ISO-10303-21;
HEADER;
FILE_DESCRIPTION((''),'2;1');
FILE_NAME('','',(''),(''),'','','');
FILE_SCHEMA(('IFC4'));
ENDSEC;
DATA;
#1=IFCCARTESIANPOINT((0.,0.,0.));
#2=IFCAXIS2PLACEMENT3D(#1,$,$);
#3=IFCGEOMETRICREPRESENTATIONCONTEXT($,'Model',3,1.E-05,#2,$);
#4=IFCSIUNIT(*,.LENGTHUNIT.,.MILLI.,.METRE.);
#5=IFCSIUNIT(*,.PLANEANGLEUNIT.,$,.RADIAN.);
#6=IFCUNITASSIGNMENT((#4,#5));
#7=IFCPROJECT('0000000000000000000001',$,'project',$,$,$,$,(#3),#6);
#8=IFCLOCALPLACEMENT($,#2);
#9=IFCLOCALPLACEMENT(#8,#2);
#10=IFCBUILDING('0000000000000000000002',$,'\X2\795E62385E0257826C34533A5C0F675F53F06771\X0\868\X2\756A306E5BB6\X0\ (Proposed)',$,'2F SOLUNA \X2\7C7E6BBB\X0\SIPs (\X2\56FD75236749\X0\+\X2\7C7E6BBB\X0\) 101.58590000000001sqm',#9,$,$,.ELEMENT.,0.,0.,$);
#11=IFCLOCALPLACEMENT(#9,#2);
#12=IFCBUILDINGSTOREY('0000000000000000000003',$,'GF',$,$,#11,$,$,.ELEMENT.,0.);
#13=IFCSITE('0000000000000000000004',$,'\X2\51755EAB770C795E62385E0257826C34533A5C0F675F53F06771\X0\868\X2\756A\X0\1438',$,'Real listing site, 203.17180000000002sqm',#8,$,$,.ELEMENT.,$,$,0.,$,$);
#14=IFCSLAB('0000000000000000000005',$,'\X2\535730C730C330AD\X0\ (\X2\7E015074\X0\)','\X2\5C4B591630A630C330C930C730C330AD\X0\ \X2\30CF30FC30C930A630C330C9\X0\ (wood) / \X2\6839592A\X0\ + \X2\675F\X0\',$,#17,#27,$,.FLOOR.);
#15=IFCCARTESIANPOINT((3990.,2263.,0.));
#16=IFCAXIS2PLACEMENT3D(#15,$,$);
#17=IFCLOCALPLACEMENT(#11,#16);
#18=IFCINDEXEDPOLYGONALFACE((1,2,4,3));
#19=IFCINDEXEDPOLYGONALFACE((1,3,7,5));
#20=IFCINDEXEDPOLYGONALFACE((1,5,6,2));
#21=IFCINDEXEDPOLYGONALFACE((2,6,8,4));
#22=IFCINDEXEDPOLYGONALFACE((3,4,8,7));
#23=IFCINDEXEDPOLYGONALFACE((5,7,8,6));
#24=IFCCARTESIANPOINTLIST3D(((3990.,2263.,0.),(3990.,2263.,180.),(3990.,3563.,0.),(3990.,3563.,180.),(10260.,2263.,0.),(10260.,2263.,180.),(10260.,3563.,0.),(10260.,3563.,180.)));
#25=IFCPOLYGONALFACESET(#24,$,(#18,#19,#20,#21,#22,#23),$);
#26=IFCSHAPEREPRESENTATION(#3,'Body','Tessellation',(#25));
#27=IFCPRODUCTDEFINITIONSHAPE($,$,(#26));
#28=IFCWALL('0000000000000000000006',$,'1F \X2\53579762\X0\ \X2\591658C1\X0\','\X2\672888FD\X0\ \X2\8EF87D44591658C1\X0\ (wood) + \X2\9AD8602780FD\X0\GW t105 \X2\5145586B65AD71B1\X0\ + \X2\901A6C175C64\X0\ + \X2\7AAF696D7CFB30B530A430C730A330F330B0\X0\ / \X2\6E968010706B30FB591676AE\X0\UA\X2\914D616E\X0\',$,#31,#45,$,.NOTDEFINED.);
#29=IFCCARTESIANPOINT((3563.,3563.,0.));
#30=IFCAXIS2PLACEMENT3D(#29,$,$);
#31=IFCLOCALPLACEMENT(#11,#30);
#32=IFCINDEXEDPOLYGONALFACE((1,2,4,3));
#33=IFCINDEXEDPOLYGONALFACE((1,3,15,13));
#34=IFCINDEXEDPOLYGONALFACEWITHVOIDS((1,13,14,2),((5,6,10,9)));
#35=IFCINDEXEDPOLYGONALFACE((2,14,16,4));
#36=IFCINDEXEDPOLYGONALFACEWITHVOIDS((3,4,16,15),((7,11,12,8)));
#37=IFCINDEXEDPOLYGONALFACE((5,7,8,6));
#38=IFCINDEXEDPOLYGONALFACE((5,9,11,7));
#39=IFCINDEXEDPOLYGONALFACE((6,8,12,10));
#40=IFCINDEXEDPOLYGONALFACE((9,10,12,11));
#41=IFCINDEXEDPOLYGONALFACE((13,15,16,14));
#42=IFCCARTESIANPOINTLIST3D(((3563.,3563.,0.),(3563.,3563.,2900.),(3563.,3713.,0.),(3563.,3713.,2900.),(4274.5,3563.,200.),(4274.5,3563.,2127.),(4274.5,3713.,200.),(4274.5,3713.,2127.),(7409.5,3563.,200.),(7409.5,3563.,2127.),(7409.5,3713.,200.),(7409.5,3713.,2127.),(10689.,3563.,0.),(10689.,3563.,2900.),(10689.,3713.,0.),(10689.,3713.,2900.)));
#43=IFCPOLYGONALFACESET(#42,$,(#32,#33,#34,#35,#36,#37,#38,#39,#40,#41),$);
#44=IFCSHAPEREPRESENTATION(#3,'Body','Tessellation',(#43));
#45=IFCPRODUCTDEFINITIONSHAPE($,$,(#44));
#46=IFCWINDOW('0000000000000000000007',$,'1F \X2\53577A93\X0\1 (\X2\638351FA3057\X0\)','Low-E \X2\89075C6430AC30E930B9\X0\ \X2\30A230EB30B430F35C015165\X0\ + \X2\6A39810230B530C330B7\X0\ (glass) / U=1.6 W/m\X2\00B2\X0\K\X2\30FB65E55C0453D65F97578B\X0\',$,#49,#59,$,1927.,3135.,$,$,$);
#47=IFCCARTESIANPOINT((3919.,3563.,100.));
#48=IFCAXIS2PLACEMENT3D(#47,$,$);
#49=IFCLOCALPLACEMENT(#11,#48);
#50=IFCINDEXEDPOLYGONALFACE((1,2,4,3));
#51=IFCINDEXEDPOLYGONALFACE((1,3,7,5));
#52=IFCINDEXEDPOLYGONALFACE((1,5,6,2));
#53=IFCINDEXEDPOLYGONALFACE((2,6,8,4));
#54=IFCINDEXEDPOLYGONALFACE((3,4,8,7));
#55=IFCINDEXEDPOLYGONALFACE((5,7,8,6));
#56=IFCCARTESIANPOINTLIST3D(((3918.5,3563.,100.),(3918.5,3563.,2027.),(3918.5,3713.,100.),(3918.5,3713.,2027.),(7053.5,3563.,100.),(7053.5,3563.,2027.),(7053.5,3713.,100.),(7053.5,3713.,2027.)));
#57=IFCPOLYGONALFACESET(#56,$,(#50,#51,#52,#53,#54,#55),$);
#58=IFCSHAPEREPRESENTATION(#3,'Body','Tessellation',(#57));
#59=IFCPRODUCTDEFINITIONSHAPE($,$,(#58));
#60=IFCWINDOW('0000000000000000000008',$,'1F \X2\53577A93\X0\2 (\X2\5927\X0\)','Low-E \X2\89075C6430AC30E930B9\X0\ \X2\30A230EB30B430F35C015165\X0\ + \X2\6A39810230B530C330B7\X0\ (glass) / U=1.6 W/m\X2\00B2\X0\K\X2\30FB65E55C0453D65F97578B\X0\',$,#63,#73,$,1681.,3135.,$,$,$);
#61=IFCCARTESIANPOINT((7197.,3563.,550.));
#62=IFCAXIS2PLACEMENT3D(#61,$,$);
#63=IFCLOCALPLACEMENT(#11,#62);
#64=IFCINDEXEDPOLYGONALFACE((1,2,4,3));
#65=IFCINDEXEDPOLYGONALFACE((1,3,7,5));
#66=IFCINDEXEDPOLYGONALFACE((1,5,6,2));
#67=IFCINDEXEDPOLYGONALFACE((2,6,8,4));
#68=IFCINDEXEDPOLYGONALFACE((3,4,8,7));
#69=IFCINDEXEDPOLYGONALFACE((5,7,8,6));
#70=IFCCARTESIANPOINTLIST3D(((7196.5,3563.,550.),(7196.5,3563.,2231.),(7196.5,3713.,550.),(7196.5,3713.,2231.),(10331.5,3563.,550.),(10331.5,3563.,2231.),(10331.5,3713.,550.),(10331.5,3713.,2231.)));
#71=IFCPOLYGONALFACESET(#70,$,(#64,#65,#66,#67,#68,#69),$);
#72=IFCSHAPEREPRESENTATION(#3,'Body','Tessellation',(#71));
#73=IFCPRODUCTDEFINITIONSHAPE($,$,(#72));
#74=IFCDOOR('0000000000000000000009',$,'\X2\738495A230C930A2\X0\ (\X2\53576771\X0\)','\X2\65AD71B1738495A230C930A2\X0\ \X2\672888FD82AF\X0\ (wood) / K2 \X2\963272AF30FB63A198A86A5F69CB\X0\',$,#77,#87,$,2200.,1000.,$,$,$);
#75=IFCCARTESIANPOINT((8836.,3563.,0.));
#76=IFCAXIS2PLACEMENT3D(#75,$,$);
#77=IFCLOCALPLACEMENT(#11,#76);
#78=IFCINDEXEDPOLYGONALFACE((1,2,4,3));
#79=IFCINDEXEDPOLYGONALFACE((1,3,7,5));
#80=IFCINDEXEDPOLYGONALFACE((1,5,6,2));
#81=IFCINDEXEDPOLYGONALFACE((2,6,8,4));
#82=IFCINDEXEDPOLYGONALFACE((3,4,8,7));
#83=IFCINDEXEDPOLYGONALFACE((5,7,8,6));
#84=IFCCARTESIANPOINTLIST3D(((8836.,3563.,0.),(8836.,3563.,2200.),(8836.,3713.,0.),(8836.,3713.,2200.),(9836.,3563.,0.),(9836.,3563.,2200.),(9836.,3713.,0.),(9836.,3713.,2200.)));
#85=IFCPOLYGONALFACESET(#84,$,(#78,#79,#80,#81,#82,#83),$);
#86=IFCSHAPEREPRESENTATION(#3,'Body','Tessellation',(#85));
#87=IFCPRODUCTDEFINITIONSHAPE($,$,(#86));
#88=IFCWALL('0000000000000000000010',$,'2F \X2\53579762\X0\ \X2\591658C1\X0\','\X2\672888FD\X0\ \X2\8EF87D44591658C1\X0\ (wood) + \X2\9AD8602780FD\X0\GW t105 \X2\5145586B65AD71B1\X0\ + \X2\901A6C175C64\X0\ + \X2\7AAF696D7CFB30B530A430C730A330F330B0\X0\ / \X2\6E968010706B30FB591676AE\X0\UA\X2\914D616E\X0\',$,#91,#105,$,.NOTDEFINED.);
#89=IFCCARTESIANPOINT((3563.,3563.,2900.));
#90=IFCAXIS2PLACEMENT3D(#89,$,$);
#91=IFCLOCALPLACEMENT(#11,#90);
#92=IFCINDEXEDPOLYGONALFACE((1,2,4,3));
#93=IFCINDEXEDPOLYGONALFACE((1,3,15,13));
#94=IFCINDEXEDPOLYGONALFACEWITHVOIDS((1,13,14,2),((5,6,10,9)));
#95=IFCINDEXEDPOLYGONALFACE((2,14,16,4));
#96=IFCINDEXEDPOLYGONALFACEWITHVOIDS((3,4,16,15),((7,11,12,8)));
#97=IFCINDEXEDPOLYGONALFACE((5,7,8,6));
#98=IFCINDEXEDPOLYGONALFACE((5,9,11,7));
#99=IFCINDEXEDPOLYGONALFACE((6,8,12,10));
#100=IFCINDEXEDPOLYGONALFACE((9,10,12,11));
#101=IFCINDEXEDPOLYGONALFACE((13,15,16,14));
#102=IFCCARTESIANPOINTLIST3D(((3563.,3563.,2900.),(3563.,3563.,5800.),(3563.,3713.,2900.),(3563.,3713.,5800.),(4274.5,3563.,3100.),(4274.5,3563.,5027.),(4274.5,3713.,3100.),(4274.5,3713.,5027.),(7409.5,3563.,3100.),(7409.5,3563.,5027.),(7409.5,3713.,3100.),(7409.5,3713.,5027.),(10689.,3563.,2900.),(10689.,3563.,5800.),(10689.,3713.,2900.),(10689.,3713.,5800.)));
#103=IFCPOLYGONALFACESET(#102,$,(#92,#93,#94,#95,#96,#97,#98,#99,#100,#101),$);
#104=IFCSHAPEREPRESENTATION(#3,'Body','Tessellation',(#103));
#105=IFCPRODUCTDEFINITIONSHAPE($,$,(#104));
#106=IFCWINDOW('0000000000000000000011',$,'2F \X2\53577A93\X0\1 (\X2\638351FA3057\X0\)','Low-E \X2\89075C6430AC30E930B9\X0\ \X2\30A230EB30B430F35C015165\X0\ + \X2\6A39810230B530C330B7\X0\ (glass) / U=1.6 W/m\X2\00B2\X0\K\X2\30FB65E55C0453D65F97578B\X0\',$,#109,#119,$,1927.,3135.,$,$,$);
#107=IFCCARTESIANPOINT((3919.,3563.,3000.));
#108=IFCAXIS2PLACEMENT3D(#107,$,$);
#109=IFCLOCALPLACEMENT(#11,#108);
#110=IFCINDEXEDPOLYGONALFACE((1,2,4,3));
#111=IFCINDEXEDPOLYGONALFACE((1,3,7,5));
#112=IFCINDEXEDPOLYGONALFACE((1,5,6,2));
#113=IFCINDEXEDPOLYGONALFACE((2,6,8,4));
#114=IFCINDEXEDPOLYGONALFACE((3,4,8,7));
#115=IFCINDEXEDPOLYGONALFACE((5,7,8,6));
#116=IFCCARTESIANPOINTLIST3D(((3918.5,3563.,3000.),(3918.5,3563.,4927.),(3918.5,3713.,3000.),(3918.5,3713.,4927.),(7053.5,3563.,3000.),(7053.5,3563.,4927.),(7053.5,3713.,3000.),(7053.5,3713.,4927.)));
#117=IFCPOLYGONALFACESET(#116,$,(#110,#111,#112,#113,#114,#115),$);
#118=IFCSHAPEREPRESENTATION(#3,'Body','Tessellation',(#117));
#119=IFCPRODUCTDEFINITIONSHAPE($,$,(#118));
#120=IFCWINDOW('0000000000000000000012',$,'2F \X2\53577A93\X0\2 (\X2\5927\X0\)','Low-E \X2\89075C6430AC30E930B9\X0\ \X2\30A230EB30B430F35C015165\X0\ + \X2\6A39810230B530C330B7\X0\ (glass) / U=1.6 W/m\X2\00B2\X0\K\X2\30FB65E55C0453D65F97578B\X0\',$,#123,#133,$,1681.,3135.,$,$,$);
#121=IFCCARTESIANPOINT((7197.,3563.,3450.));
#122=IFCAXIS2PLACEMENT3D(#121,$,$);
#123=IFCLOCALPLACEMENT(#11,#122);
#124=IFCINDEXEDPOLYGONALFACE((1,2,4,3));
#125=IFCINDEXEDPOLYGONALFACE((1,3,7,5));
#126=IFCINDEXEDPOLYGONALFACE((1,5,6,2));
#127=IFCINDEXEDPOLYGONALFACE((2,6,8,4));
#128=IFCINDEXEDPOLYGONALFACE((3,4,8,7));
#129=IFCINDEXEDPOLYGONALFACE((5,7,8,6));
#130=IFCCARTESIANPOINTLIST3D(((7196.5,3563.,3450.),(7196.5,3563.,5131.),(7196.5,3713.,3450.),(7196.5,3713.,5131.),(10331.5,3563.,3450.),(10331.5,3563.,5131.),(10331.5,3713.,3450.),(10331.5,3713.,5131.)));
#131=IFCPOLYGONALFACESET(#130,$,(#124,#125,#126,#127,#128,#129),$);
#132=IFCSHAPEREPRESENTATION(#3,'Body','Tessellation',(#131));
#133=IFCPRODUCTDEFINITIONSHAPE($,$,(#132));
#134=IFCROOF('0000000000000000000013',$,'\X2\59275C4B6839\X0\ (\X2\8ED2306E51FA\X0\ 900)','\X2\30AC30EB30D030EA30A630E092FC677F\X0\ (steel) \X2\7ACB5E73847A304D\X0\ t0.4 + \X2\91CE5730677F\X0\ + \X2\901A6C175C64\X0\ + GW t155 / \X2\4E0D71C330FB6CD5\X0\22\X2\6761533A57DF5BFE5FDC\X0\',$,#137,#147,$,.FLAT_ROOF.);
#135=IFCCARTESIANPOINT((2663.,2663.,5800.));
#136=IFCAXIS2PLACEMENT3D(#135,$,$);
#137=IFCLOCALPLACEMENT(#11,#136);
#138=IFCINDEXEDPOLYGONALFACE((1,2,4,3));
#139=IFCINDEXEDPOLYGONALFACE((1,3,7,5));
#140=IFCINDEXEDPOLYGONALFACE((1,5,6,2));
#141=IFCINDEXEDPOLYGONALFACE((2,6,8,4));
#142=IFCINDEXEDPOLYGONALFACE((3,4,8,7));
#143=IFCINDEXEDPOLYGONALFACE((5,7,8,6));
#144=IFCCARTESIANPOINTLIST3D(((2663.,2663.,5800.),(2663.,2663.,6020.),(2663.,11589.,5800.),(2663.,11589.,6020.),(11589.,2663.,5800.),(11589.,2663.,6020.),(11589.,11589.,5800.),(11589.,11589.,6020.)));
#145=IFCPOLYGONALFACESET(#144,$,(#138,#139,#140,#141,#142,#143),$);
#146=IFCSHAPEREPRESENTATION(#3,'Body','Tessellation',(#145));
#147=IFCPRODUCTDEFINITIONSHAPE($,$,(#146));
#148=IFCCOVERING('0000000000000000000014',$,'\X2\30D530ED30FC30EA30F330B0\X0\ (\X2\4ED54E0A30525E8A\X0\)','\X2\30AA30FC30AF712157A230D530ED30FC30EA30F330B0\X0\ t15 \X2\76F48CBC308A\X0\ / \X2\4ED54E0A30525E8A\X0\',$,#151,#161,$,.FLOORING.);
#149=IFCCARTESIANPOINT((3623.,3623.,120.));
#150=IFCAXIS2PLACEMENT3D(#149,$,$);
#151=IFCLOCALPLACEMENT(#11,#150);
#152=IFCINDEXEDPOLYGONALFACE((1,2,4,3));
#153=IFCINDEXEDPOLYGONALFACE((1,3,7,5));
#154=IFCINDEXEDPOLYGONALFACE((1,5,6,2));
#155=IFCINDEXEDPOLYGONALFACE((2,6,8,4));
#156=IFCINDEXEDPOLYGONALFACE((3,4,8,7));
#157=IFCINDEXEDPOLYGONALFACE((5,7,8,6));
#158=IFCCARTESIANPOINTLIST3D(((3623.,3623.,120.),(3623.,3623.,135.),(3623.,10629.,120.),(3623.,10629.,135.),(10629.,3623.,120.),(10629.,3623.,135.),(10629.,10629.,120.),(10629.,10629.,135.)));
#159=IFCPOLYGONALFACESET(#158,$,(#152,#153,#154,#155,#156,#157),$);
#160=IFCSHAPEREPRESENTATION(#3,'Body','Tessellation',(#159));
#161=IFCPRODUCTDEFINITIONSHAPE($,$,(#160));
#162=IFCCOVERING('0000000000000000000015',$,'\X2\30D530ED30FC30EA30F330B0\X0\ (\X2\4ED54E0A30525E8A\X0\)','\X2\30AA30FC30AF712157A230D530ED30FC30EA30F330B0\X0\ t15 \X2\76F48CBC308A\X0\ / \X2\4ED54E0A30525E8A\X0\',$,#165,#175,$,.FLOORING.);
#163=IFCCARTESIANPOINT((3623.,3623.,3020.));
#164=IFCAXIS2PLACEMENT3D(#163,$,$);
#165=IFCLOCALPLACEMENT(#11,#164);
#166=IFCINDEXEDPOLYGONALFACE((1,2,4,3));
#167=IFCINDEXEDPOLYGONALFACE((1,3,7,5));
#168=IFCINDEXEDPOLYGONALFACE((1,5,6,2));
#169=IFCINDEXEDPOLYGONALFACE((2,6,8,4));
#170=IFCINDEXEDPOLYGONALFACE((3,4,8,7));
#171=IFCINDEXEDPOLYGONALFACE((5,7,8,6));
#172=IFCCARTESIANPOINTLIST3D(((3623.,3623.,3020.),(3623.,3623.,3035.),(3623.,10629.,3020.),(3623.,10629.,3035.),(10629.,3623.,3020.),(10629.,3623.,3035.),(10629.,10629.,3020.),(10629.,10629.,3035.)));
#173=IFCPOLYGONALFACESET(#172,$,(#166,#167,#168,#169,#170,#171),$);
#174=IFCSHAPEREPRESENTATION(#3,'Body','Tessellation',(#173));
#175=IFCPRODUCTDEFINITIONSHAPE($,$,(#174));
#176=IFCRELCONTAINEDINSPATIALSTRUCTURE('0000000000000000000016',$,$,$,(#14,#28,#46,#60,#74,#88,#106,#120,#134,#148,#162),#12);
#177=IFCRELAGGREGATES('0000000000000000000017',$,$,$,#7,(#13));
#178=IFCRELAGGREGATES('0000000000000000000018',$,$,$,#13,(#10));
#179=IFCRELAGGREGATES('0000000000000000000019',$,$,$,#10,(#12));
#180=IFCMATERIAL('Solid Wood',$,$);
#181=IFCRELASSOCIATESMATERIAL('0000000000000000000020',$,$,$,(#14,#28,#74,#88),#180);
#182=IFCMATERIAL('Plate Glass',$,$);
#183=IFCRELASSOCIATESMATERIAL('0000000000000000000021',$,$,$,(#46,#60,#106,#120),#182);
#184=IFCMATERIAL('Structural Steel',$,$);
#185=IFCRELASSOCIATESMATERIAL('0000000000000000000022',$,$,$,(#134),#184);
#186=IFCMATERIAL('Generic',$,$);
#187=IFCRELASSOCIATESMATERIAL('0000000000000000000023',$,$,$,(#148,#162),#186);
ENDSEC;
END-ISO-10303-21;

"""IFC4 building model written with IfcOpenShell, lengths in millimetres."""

from ifc_helpers import new_model, si_unit, frame, frame_2d, origin, place, context, project, spatial, rectangle, extrude, material, element, fill, save


model = new_model("IFC4")

# Units and contexts
model_context = context("Model", 3, precision=1e-05, world=origin())
ifc_project = project(units=[si_unit("LENGTHUNIT", "METRE", prefix="MILLI"), si_unit("PLANEANGLEUNIT", "RADIAN")], contexts=[model_context])

# Site, building, storey
site_placement = place(None, origin())
site = spatial("IfcSite", under=ifc_project, at=site_placement, Name="兵庫県神戸市垂水区小束台東868番1438", ObjectType="Real listing site, 203.17180000000002sqm", CompositionType="ELEMENT", RefElevation=0.0)
building_placement = place(site_placement, origin())
building = spatial("IfcBuilding", under=site, at=building_placement, Name="神戸市垂水区小束台東868番の家 (Proposed)", ObjectType="2F SOLUNA 籾殻SIPs (国産杉+籾殻) 101.58590000000001sqm", CompositionType="ELEMENT", ElevationOfRefHeight=0.0, ElevationOfTerrain=0.0)
storey_placement = place(building_placement, origin())
storey = spatial("IfcBuildingStorey", under=building, at=storey_placement, Name="GF", CompositionType="ELEMENT", Elevation=0.0)

# Slab
ifc_material_1 = material(Name="Solid Wood")
slab_1_placement = place(storey_placement, frame((3990.0, 2263.0, 0.0)))
element("IfcSlab", 1, at=slab_1_placement, inside=storey, material=ifc_material_1, Name="南デッキ (縁側)", Description="屋外ウッドデッキ ハードウッド (wood) / 根太 + 束", PredefinedType="FLOOR", context=model_context, shape_type="SweptSolid", body=[
    extrude(rectangle(XDim=6270.0, YDim=1300.0, at=frame_2d((3135.0, 650.0))), frame((3990.0, 2263.0, 0.0)), (0.0, 0.0, 1.0), 180.0),
])

# Wall, openings, windows, door
wall_1_placement = place(storey_placement, frame((3563.0, 3563.0, 0.0)))
wall_1 = element("IfcWall", 2, at=wall_1_placement, inside=storey, material=ifc_material_1, Name="1F 南面 外壁", Description="木製 軸組外壁 (wood) + 高性能GW t105 充填断熱 + 通気層 + 窯業系サイディング / 準耐火・外皮UA配慮", PredefinedType="NOTDEFINED", context=model_context, shape_type="SweptSolid", body=[
    extrude(rectangle(XDim=7126.0, YDim=150.0, at=frame_2d((3563.0, 75.0))), frame((3563.0, 3563.0, 0.0)), (0.0, 0.0, 1.0), 2900.0),
])
opening_1_placement = place(storey_placement, frame((3919.0, 3563.0, 100.0)))
opening_1 = element("IfcOpeningElement", 3, at=opening_1_placement, cuts=wall_1, PredefinedType="NOTDEFINED", context=model_context, shape_type="SweptSolid", body=[
    extrude(rectangle(XDim=3135.0, YDim=150.0, at=frame_2d((1567.0, 75.0))), frame((3919.0, 3563.0, 100.0)), (0.0, 0.0, 1.0), 1927.0),
])
opening_2_placement = place(storey_placement, frame((7197.0, 3563.0, 550.0)))
opening_2 = element("IfcOpeningElement", 4, at=opening_2_placement, cuts=wall_1, PredefinedType="NOTDEFINED", context=model_context, shape_type="SweptSolid", body=[
    extrude(rectangle(XDim=3135.0, YDim=150.0, at=frame_2d((1567.0, 75.0))), frame((7197.0, 3563.0, 550.0)), (0.0, 0.0, 1.0), 1681.0),
])
opening_3_placement = place(storey_placement, frame((8836.0, 3563.0, 0.0)))
opening_3 = element("IfcOpeningElement", 5, at=opening_3_placement, cuts=wall_1, PredefinedType="NOTDEFINED", context=model_context, shape_type="SweptSolid", body=[
    extrude(rectangle(XDim=1000.0, YDim=150.0, at=frame_2d((500.0, 75.0))), frame((8836.0, 3563.0, 0.0)), (0.0, 0.0, 1.0), 2200.0),
])
ifc_material_2 = material(Name="Plate Glass")
window_1_placement = place(storey_placement, frame((3919.0, 3563.0, 100.0)))
window_1 = element("IfcWindow", 6, at=window_1_placement, inside=storey, material=ifc_material_2, Name="1F 南窓1 (掃出し)", Description="Low-E 複層ガラス アルゴン封入 + 樹脂サッシ (glass) / U=1.6 W/m²K・日射取得型", OverallHeight=1927.0, OverallWidth=3135.0, context=model_context, shape_type="SweptSolid", body=[
    extrude(rectangle(XDim=3135.0, YDim=150.0, at=frame_2d((1567.0, 75.0))), frame((3919.0, 3563.0, 100.0)), (0.0, 0.0, 1.0), 1927.0),
])
fill(opening_1, window_1)
window_2_placement = place(storey_placement, frame((7197.0, 3563.0, 550.0)))
window_2 = element("IfcWindow", 7, at=window_2_placement, inside=storey, material=ifc_material_2, Name="1F 南窓2 (大)", Description="Low-E 複層ガラス アルゴン封入 + 樹脂サッシ (glass) / U=1.6 W/m²K・日射取得型", OverallHeight=1681.0, OverallWidth=3135.0, context=model_context, shape_type="SweptSolid", body=[
    extrude(rectangle(XDim=3135.0, YDim=150.0, at=frame_2d((1567.0, 75.0))), frame((7197.0, 3563.0, 550.0)), (0.0, 0.0, 1.0), 1681.0),
])
fill(opening_2, window_2)
door_placement = place(storey_placement, frame((8836.0, 3563.0, 0.0)))
door = element("IfcDoor", 8, at=door_placement, inside=storey, material=ifc_material_1, Name="玄関ドア (南東)", Description="断熱玄関ドア 木製芯 (wood) / K2 防犯・採風機構", OverallHeight=2200.0, OverallWidth=1000.0, context=model_context, shape_type="SweptSolid", body=[
    extrude(rectangle(XDim=1000.0, YDim=150.0, at=frame_2d((500.0, 75.0))), frame((8836.0, 3563.0, 0.0)), (0.0, 0.0, 1.0), 2200.0),
])
fill(opening_3, door)

# Wall, openings, windows
wall_2_placement = place(storey_placement, frame((3563.0, 3563.0, 2900.0)))
wall_2 = element("IfcWall", 9, at=wall_2_placement, inside=storey, material=ifc_material_1, Name="2F 南面 外壁", Description="木製 軸組外壁 (wood) + 高性能GW t105 充填断熱 + 通気層 + 窯業系サイディング / 準耐火・外皮UA配慮", PredefinedType="NOTDEFINED", context=model_context, shape_type="SweptSolid", body=[
    extrude(rectangle(XDim=7126.0, YDim=150.0, at=frame_2d((3563.0, 75.0))), frame((3563.0, 3563.0, 2900.0)), (0.0, 0.0, 1.0), 2900.0),
])
opening_4_placement = place(storey_placement, frame((3919.0, 3563.0, 3000.0)))
opening_4 = element("IfcOpeningElement", 10, at=opening_4_placement, cuts=wall_2, PredefinedType="NOTDEFINED", context=model_context, shape_type="SweptSolid", body=[
    extrude(rectangle(XDim=3135.0, YDim=150.0, at=frame_2d((1567.0, 75.0))), frame((3919.0, 3563.0, 3000.0)), (0.0, 0.0, 1.0), 1927.0),
])
opening_5_placement = place(storey_placement, frame((7197.0, 3563.0, 3450.0)))
opening_5 = element("IfcOpeningElement", 11, at=opening_5_placement, cuts=wall_2, PredefinedType="NOTDEFINED", context=model_context, shape_type="SweptSolid", body=[
    extrude(rectangle(XDim=3135.0, YDim=150.0, at=frame_2d((1567.0, 75.0))), frame((7197.0, 3563.0, 3450.0)), (0.0, 0.0, 1.0), 1681.0),
])
window_3_placement = place(storey_placement, frame((3919.0, 3563.0, 3000.0)))
window_3 = element("IfcWindow", 12, at=window_3_placement, inside=storey, material=ifc_material_2, Name="2F 南窓1 (掃出し)", Description="Low-E 複層ガラス アルゴン封入 + 樹脂サッシ (glass) / U=1.6 W/m²K・日射取得型", OverallHeight=1927.0, OverallWidth=3135.0, context=model_context, shape_type="SweptSolid", body=[
    extrude(rectangle(XDim=3135.0, YDim=150.0, at=frame_2d((1567.0, 75.0))), frame((3919.0, 3563.0, 3000.0)), (0.0, 0.0, 1.0), 1927.0),
])
fill(opening_4, window_3)
window_4_placement = place(storey_placement, frame((7197.0, 3563.0, 3450.0)))
window_4 = element("IfcWindow", 13, at=window_4_placement, inside=storey, material=ifc_material_2, Name="2F 南窓2 (大)", Description="Low-E 複層ガラス アルゴン封入 + 樹脂サッシ (glass) / U=1.6 W/m²K・日射取得型", OverallHeight=1681.0, OverallWidth=3135.0, context=model_context, shape_type="SweptSolid", body=[
    extrude(rectangle(XDim=3135.0, YDim=150.0, at=frame_2d((1567.0, 75.0))), frame((7197.0, 3563.0, 3450.0)), (0.0, 0.0, 1.0), 1681.0),
])
fill(opening_5, window_4)

# Roof
ifc_material_3 = material(Name="Structural Steel")
roof_placement = place(storey_placement, frame((2663.0, 2663.0, 5800.0)))
element("IfcRoof", 14, at=roof_placement, inside=storey, material=ifc_material_3, Name="大屋根 (軒の出 900)", Description="ガルバリウム鋼板 (steel) 立平葺き t0.4 + 野地板 + 通気層 + GW t155 / 不燃・法22条区域対応", PredefinedType="FLAT_ROOF", context=model_context, shape_type="SweptSolid", body=[
    extrude(rectangle(XDim=8926.0, YDim=8926.0, at=frame_2d((4463.0, 4463.0))), frame((2663.0, 2663.0, 5800.0)), (0.0, 0.0, 1.0), 220.0),
])

# Coverings
ifc_material_4 = material(Name="Generic")
covering_1_placement = place(storey_placement, frame((3623.0, 3623.0, 120.0)))
element("IfcCovering", 15, at=covering_1_placement, inside=storey, material=ifc_material_4, Name="フローリング (仕上げ床)", Description="オーク無垢フローリング t15 直貼り / 仕上げ床", PredefinedType="FLOORING", context=model_context, shape_type="SweptSolid", body=[
    extrude(rectangle(XDim=7006.0, YDim=7006.0, at=frame_2d((3503.0, 3503.0))), frame((3623.0, 3623.0, 120.0)), (0.0, 0.0, 1.0), 15.0),
])
covering_2_placement = place(storey_placement, frame((3623.0, 3623.0, 3020.0)))
element("IfcCovering", 16, at=covering_2_placement, inside=storey, material=ifc_material_4, Name="フローリング (仕上げ床)", Description="オーク無垢フローリング t15 直貼り / 仕上げ床", PredefinedType="FLOORING", context=model_context, shape_type="SweptSolid", body=[
    extrude(rectangle(XDim=7006.0, YDim=7006.0, at=frame_2d((3503.0, 3503.0))), frame((3623.0, 3623.0, 3020.0)), (0.0, 0.0, 1.0), 15.0),
])

save(model, "model.ifc")
